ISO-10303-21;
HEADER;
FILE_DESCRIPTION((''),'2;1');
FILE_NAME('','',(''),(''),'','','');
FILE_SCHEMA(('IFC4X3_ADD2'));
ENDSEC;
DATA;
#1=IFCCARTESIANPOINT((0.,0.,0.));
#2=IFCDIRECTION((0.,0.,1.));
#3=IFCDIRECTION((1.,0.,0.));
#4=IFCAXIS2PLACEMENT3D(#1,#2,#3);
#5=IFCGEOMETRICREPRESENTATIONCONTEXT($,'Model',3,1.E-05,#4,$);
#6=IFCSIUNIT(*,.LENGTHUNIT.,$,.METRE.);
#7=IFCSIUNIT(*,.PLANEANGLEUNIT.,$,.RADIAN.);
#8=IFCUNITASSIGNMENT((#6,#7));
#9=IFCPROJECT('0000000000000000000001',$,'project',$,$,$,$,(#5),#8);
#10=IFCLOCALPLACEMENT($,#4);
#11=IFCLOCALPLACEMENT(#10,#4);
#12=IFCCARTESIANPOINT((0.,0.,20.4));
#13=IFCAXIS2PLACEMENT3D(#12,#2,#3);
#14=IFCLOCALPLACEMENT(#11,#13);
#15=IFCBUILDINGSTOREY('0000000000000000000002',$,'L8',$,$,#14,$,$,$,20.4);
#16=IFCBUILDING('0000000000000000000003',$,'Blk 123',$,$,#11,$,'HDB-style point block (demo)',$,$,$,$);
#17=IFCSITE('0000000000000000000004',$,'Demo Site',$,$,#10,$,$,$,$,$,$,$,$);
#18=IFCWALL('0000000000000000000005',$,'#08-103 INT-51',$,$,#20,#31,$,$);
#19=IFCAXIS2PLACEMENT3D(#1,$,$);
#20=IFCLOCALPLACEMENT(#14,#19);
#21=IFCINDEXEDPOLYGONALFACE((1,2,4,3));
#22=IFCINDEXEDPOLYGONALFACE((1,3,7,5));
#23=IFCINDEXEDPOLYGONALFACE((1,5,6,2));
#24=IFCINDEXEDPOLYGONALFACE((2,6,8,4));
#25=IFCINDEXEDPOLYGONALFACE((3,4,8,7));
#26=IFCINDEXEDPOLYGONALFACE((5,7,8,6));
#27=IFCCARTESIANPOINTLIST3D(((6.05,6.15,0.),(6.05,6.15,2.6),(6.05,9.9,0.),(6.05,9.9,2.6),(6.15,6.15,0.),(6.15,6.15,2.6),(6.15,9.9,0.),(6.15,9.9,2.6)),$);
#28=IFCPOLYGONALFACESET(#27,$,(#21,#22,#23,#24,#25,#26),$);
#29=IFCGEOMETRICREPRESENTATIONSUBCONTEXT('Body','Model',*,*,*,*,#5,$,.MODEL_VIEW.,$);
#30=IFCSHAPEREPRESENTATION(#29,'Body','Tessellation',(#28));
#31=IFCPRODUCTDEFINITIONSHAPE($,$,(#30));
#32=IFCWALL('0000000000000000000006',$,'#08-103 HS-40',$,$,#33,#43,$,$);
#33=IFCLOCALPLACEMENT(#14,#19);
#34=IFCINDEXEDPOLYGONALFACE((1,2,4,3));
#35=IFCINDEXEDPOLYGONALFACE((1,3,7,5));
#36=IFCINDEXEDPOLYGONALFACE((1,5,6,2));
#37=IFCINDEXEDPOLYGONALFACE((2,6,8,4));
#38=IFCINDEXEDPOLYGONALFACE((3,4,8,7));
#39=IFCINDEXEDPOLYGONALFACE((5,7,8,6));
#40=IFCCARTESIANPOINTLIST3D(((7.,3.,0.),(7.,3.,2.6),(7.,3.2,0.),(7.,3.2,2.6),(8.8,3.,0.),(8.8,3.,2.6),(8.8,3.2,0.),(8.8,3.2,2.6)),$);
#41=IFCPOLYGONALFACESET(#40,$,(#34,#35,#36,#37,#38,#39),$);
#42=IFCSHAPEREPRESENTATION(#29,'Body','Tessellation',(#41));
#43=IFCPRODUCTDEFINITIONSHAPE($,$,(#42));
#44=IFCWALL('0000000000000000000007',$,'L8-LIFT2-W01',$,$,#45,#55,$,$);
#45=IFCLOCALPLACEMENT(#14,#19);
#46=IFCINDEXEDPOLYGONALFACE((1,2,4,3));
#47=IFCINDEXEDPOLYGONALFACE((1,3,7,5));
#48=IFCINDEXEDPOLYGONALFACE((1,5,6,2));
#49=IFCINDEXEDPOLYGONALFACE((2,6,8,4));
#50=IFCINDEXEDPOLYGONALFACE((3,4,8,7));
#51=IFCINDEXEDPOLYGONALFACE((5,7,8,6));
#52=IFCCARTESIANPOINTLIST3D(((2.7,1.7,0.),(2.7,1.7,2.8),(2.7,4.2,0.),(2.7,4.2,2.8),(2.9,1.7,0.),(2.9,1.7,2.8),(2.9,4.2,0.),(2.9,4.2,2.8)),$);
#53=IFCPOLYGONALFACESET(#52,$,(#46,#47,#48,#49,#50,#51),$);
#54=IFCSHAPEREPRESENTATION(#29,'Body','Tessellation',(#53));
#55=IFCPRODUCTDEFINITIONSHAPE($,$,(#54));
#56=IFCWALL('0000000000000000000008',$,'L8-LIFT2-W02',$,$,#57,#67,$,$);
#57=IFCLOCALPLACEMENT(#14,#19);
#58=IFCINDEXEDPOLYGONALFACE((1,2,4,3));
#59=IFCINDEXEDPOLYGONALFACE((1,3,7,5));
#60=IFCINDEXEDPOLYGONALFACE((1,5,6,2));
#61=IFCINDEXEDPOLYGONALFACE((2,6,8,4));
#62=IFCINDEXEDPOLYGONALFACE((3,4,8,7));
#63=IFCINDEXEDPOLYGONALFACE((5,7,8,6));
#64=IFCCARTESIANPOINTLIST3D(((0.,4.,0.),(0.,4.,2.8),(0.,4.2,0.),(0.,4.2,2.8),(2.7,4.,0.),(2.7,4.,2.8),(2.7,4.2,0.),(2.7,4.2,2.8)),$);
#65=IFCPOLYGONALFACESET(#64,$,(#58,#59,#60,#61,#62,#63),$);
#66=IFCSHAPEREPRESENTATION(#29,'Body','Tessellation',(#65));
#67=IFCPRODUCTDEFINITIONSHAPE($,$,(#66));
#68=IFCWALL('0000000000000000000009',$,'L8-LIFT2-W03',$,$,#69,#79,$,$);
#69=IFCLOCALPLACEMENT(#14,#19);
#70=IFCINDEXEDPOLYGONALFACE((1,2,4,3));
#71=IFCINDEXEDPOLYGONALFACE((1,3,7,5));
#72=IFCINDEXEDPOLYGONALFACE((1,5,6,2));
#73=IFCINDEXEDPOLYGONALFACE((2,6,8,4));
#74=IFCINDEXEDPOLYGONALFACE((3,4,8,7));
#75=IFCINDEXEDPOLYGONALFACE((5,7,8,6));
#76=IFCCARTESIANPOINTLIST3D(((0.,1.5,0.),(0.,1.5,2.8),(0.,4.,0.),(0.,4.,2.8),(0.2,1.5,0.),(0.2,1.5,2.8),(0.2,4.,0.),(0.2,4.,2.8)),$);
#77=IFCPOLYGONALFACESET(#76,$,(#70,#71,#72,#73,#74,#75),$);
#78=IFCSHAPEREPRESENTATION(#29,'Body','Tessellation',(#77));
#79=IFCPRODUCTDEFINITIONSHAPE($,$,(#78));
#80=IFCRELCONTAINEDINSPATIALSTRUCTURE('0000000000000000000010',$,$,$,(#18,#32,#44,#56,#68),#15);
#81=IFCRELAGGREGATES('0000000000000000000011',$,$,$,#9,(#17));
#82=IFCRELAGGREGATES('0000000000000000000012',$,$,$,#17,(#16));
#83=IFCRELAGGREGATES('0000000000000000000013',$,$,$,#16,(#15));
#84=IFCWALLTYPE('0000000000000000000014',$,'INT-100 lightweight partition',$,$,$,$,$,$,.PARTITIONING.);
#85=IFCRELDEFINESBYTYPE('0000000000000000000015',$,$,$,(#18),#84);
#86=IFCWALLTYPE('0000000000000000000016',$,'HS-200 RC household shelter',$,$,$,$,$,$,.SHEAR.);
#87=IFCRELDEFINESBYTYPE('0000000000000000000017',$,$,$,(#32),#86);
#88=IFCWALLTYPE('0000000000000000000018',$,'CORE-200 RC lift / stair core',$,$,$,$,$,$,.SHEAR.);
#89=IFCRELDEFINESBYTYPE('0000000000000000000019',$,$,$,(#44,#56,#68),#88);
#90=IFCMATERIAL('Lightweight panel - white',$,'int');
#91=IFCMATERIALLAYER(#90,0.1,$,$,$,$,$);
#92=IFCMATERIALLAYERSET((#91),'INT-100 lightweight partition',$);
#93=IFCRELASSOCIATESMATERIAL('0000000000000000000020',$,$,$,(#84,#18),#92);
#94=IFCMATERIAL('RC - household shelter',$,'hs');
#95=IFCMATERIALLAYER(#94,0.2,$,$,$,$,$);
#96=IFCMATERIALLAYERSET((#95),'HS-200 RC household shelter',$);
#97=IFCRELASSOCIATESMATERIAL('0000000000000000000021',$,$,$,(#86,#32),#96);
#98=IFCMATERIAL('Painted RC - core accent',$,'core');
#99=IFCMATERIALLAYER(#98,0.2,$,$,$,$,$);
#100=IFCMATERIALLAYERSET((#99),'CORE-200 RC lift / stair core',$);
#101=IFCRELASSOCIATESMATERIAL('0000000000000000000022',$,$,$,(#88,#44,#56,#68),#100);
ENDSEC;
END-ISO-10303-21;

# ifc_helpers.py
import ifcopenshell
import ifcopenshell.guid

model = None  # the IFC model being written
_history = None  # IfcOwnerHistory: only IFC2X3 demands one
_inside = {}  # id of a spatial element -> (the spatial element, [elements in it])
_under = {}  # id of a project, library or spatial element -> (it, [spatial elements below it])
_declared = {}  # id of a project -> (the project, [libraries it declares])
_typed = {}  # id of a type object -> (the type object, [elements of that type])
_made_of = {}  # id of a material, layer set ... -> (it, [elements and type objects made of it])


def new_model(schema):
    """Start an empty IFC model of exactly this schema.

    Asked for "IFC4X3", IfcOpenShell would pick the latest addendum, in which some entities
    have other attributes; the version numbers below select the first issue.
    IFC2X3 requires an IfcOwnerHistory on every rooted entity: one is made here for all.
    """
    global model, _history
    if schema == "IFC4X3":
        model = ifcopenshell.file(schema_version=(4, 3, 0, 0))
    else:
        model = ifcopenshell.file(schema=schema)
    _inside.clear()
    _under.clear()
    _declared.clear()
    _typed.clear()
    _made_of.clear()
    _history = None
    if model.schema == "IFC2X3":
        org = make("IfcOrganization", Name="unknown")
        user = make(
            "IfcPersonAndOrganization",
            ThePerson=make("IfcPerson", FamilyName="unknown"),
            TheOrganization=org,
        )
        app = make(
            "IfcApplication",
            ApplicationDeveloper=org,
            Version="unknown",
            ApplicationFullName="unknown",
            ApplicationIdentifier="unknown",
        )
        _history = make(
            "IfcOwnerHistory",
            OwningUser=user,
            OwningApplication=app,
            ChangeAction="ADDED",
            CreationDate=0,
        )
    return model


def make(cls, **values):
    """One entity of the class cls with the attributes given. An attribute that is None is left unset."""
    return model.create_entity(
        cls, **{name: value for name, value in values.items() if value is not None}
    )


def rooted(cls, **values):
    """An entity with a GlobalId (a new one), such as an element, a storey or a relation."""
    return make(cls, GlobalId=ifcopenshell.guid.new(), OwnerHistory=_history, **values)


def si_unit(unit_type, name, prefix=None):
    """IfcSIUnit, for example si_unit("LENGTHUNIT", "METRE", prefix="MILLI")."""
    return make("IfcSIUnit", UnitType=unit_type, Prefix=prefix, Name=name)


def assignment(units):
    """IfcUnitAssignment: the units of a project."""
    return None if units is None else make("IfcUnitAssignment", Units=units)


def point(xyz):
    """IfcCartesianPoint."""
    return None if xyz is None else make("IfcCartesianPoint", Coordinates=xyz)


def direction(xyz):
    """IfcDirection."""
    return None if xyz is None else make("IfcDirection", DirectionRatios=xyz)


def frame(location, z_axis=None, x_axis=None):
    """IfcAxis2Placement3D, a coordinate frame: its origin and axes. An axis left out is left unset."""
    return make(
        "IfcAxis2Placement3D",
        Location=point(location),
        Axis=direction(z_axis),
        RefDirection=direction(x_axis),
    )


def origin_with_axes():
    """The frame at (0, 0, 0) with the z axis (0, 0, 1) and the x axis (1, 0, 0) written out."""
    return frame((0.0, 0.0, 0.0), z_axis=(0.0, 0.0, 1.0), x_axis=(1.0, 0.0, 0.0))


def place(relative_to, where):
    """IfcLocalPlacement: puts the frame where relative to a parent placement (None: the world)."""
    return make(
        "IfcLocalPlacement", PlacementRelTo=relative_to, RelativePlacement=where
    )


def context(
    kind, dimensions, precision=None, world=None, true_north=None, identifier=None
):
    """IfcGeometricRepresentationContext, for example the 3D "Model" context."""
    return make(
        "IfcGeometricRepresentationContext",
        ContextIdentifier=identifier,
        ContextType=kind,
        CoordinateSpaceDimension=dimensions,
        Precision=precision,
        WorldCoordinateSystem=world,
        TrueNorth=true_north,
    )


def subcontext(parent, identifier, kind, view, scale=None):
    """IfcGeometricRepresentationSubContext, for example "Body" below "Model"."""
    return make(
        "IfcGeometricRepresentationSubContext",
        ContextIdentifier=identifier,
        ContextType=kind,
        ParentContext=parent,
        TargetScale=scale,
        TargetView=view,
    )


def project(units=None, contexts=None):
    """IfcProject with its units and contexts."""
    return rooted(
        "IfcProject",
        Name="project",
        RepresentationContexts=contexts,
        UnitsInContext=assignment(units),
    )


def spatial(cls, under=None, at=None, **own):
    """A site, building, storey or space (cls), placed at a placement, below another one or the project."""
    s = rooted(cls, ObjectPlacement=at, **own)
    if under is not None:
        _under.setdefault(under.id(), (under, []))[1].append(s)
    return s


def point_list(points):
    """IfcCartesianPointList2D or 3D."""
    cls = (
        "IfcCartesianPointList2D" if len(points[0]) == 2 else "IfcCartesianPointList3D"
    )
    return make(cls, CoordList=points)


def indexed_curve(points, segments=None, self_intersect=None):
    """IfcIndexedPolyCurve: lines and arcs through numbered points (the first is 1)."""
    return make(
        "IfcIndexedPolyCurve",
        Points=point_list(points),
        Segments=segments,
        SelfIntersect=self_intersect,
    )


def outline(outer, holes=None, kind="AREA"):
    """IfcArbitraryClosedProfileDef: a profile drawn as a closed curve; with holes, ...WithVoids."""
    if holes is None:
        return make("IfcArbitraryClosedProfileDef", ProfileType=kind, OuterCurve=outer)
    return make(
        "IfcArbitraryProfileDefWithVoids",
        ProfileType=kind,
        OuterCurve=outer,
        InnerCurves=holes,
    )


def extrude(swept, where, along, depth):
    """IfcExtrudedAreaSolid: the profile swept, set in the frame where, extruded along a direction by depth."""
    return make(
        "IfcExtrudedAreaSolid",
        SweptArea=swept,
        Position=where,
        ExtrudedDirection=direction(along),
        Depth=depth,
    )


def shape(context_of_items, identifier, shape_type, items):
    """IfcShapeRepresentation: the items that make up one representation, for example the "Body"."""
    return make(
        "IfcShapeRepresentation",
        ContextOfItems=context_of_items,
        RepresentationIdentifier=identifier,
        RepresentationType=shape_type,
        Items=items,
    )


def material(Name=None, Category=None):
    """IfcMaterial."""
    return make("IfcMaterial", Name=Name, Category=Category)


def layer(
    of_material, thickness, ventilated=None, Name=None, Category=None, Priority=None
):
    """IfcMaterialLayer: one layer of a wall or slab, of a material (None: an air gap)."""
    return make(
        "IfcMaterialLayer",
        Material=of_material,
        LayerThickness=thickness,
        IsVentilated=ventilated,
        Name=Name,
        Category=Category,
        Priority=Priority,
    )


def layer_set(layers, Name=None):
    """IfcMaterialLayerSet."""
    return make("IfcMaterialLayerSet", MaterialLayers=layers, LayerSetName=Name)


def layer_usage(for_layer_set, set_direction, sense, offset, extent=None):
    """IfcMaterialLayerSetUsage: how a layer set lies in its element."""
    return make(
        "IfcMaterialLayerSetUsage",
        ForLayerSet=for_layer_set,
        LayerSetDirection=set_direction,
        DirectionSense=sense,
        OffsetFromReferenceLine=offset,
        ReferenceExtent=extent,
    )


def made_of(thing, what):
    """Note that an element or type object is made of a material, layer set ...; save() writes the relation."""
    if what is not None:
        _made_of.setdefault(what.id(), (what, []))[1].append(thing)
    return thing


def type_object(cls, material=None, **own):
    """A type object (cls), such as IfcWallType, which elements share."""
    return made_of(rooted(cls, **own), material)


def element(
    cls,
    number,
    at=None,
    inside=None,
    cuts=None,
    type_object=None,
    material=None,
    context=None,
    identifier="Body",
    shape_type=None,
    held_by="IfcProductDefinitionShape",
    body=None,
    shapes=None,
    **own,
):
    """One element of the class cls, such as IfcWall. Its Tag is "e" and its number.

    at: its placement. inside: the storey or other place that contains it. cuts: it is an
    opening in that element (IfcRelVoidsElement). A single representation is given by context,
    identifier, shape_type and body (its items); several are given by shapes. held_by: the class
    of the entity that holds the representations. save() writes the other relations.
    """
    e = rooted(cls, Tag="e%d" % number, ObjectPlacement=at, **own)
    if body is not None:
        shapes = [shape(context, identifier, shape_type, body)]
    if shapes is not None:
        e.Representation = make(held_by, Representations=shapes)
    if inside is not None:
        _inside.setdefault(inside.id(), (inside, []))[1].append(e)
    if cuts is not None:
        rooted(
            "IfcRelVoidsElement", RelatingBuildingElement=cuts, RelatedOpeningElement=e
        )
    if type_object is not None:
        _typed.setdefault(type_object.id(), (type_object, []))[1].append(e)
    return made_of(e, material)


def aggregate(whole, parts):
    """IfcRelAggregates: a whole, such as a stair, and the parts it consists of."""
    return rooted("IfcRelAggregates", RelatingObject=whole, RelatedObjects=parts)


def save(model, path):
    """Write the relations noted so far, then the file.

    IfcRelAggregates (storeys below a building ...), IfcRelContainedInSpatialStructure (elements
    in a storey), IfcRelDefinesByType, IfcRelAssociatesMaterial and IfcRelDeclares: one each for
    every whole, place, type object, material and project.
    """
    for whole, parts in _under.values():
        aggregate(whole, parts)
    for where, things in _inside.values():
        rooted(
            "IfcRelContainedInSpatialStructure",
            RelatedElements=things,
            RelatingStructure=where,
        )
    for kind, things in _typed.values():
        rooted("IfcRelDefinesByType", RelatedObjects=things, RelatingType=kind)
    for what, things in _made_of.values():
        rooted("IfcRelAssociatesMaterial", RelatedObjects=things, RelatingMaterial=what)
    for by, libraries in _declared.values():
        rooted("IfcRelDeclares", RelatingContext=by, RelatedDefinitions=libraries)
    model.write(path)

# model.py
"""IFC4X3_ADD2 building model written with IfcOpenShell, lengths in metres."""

from ifc_helpers import new_model, si_unit, frame, origin_with_axes, place, context, subcontext, project, spatial, indexed_curve, outline, extrude, material, layer, layer_set, layer_usage, type_object, element, save


model = new_model("IFC4X3_ADD2")

# Units and contexts
model_context = context("Model", 3, precision=1e-05, world=origin_with_axes())
body_context = subcontext(model_context, "Body", "Model", "MODEL_VIEW")
ifc_project = project(units=[si_unit("LENGTHUNIT", "METRE"), si_unit("PLANEANGLEUNIT", "RADIAN")], contexts=[model_context])

# Site, building, storey
site_placement = place(None, origin_with_axes())
site = spatial("IfcSite", under=ifc_project, at=site_placement, Name="Demo Site")
building_placement = place(site_placement, origin_with_axes())
building = spatial("IfcBuilding", under=site, at=building_placement, Name="Blk 123", LongName="HDB-style point block (demo)")
storey_placement = place(building_placement, frame((0.0, 0.0, 20.4), z_axis=(0.0, 0.0, 1.0), x_axis=(1.0, 0.0, 0.0)))
storey = spatial("IfcBuildingStorey", under=building, at=storey_placement, Name="L8", Elevation=20.4)

# Shared definitions
ifc_material_1 = material(Name="Lightweight panel - white", Category="int")
ifc_layer_1 = layer(ifc_material_1, 0.1)
ifc_layer_set_1 = layer_set([ifc_layer_1], Name="INT-100 lightweight partition")
ifc_layer_usage_1 = layer_usage(ifc_layer_set_1, "AXIS2", "POSITIVE", -0.05)
wall_type_1 = type_object("IfcWallType", Name="INT-100 lightweight partition", PredefinedType="PARTITIONING", material=ifc_layer_set_1)

# Walls
wall_1_placement = place(storey_placement, frame((6.1, 6.15, 0.0), z_axis=(0.0, 0.0, 1.0), x_axis=(0.0, 1.0, 0.0)))
element("IfcWall", 1, at=wall_1_placement, inside=storey, type_object=wall_type_1, material=ifc_layer_usage_1, Name="#08-103 INT-51", context=body_context, shape_type="SweptSolid", body=[
    extrude(outline(indexed_curve([(0.0, 0.0), (0.0, 0.1), (3.75, 0.1), (3.75, 0.0), (0.0, 0.0)], self_intersect=False)), frame((0.0, -0.05, 0.0), z_axis=(0.0, 0.0, 1.0), x_axis=(1.0, 0.0, 0.0)), (0.0, 0.0, 1.0), 2.6),
])
ifc_material_2 = material(Name="RC - household shelter", Category="hs")
ifc_layer_2 = layer(ifc_material_2, 0.2)
ifc_layer_set_2 = layer_set([ifc_layer_2], Name="HS-200 RC household shelter")
ifc_layer_usage_2 = layer_usage(ifc_layer_set_2, "AXIS2", "POSITIVE", -0.1)
wall_type_2 = type_object("IfcWallType", Name="HS-200 RC household shelter", PredefinedType="SHEAR", material=ifc_layer_set_2)
wall_2_placement = place(storey_placement, frame((7.0, 3.1, 0.0), z_axis=(0.0, 0.0, 1.0), x_axis=(1.0, 0.0, 0.0)))
element("IfcWall", 2, at=wall_2_placement, inside=storey, type_object=wall_type_2, material=ifc_layer_usage_2, Name="#08-103 HS-40", context=body_context, shape_type="SweptSolid", body=[
    extrude(outline(indexed_curve([(0.0, 0.0), (0.0, 0.2), (1.8, 0.2), (1.8, 0.0), (0.0, 0.0)], self_intersect=False)), frame((0.0, -0.1, 0.0), z_axis=(0.0, 0.0, 1.0), x_axis=(1.0, 0.0, 0.0)), (0.0, 0.0, 1.0), 2.6),
])
ifc_material_3 = material(Name="Painted RC - core accent", Category="core")
ifc_layer_3 = layer(ifc_material_3, 0.2)
ifc_layer_set_3 = layer_set([ifc_layer_3], Name="CORE-200 RC lift / stair core")
ifc_layer_usage_3 = layer_usage(ifc_layer_set_3, "AXIS2", "POSITIVE", 0.0)
wall_type_3 = type_object("IfcWallType", Name="CORE-200 RC lift / stair core", PredefinedType="SHEAR", material=ifc_layer_set_3)
wall_3_placement = place(storey_placement, frame((2.9, 1.7, 0.0), z_axis=(0.0, 0.0, 1.0), x_axis=(0.0, 1.0, 0.0)))
element("IfcWall", 3, at=wall_3_placement, inside=storey, type_object=wall_type_3, material=ifc_layer_usage_3, Name="L8-LIFT2-W01", context=body_context, shape_type="SweptSolid", body=[
    extrude(outline(indexed_curve([(0.0, 0.0), (0.0, 0.2), (2.5, 0.2), (2.5, 0.0), (0.0, 0.0)], self_intersect=False)), origin_with_axes(), (0.0, 0.0, 1.0), 2.8),
])
wall_4_placement = place(storey_placement, frame((2.7, 4.2, 0.0), z_axis=(0.0, 0.0, 1.0), x_axis=(-1.0, 0.0, 0.0)))
element("IfcWall", 4, at=wall_4_placement, inside=storey, type_object=wall_type_3, material=ifc_layer_usage_3, Name="L8-LIFT2-W02", context=body_context, shape_type="SweptSolid", body=[
    extrude(outline(indexed_curve([(0.0, 0.0), (0.0, 0.2), (2.7, 0.2), (2.7, 0.0), (0.0, 0.0)], self_intersect=False)), origin_with_axes(), (0.0, 0.0, 1.0), 2.8),
])
wall_5_placement = place(storey_placement, frame((0.0, 4.0, 0.0), z_axis=(0.0, 0.0, 1.0), x_axis=(0.0, -1.0, 0.0)))
element("IfcWall", 5, at=wall_5_placement, inside=storey, type_object=wall_type_3, material=ifc_layer_usage_3, Name="L8-LIFT2-W03", context=body_context, shape_type="SweptSolid", body=[
    extrude(outline(indexed_curve([(0.0, 0.0), (0.0, 0.2), (2.5, 0.2), (2.5, 0.0), (0.0, 0.0)], self_intersect=False)), origin_with_axes(), (0.0, 0.0, 1.0), 2.8),
])

save(model, "model.ifc")
